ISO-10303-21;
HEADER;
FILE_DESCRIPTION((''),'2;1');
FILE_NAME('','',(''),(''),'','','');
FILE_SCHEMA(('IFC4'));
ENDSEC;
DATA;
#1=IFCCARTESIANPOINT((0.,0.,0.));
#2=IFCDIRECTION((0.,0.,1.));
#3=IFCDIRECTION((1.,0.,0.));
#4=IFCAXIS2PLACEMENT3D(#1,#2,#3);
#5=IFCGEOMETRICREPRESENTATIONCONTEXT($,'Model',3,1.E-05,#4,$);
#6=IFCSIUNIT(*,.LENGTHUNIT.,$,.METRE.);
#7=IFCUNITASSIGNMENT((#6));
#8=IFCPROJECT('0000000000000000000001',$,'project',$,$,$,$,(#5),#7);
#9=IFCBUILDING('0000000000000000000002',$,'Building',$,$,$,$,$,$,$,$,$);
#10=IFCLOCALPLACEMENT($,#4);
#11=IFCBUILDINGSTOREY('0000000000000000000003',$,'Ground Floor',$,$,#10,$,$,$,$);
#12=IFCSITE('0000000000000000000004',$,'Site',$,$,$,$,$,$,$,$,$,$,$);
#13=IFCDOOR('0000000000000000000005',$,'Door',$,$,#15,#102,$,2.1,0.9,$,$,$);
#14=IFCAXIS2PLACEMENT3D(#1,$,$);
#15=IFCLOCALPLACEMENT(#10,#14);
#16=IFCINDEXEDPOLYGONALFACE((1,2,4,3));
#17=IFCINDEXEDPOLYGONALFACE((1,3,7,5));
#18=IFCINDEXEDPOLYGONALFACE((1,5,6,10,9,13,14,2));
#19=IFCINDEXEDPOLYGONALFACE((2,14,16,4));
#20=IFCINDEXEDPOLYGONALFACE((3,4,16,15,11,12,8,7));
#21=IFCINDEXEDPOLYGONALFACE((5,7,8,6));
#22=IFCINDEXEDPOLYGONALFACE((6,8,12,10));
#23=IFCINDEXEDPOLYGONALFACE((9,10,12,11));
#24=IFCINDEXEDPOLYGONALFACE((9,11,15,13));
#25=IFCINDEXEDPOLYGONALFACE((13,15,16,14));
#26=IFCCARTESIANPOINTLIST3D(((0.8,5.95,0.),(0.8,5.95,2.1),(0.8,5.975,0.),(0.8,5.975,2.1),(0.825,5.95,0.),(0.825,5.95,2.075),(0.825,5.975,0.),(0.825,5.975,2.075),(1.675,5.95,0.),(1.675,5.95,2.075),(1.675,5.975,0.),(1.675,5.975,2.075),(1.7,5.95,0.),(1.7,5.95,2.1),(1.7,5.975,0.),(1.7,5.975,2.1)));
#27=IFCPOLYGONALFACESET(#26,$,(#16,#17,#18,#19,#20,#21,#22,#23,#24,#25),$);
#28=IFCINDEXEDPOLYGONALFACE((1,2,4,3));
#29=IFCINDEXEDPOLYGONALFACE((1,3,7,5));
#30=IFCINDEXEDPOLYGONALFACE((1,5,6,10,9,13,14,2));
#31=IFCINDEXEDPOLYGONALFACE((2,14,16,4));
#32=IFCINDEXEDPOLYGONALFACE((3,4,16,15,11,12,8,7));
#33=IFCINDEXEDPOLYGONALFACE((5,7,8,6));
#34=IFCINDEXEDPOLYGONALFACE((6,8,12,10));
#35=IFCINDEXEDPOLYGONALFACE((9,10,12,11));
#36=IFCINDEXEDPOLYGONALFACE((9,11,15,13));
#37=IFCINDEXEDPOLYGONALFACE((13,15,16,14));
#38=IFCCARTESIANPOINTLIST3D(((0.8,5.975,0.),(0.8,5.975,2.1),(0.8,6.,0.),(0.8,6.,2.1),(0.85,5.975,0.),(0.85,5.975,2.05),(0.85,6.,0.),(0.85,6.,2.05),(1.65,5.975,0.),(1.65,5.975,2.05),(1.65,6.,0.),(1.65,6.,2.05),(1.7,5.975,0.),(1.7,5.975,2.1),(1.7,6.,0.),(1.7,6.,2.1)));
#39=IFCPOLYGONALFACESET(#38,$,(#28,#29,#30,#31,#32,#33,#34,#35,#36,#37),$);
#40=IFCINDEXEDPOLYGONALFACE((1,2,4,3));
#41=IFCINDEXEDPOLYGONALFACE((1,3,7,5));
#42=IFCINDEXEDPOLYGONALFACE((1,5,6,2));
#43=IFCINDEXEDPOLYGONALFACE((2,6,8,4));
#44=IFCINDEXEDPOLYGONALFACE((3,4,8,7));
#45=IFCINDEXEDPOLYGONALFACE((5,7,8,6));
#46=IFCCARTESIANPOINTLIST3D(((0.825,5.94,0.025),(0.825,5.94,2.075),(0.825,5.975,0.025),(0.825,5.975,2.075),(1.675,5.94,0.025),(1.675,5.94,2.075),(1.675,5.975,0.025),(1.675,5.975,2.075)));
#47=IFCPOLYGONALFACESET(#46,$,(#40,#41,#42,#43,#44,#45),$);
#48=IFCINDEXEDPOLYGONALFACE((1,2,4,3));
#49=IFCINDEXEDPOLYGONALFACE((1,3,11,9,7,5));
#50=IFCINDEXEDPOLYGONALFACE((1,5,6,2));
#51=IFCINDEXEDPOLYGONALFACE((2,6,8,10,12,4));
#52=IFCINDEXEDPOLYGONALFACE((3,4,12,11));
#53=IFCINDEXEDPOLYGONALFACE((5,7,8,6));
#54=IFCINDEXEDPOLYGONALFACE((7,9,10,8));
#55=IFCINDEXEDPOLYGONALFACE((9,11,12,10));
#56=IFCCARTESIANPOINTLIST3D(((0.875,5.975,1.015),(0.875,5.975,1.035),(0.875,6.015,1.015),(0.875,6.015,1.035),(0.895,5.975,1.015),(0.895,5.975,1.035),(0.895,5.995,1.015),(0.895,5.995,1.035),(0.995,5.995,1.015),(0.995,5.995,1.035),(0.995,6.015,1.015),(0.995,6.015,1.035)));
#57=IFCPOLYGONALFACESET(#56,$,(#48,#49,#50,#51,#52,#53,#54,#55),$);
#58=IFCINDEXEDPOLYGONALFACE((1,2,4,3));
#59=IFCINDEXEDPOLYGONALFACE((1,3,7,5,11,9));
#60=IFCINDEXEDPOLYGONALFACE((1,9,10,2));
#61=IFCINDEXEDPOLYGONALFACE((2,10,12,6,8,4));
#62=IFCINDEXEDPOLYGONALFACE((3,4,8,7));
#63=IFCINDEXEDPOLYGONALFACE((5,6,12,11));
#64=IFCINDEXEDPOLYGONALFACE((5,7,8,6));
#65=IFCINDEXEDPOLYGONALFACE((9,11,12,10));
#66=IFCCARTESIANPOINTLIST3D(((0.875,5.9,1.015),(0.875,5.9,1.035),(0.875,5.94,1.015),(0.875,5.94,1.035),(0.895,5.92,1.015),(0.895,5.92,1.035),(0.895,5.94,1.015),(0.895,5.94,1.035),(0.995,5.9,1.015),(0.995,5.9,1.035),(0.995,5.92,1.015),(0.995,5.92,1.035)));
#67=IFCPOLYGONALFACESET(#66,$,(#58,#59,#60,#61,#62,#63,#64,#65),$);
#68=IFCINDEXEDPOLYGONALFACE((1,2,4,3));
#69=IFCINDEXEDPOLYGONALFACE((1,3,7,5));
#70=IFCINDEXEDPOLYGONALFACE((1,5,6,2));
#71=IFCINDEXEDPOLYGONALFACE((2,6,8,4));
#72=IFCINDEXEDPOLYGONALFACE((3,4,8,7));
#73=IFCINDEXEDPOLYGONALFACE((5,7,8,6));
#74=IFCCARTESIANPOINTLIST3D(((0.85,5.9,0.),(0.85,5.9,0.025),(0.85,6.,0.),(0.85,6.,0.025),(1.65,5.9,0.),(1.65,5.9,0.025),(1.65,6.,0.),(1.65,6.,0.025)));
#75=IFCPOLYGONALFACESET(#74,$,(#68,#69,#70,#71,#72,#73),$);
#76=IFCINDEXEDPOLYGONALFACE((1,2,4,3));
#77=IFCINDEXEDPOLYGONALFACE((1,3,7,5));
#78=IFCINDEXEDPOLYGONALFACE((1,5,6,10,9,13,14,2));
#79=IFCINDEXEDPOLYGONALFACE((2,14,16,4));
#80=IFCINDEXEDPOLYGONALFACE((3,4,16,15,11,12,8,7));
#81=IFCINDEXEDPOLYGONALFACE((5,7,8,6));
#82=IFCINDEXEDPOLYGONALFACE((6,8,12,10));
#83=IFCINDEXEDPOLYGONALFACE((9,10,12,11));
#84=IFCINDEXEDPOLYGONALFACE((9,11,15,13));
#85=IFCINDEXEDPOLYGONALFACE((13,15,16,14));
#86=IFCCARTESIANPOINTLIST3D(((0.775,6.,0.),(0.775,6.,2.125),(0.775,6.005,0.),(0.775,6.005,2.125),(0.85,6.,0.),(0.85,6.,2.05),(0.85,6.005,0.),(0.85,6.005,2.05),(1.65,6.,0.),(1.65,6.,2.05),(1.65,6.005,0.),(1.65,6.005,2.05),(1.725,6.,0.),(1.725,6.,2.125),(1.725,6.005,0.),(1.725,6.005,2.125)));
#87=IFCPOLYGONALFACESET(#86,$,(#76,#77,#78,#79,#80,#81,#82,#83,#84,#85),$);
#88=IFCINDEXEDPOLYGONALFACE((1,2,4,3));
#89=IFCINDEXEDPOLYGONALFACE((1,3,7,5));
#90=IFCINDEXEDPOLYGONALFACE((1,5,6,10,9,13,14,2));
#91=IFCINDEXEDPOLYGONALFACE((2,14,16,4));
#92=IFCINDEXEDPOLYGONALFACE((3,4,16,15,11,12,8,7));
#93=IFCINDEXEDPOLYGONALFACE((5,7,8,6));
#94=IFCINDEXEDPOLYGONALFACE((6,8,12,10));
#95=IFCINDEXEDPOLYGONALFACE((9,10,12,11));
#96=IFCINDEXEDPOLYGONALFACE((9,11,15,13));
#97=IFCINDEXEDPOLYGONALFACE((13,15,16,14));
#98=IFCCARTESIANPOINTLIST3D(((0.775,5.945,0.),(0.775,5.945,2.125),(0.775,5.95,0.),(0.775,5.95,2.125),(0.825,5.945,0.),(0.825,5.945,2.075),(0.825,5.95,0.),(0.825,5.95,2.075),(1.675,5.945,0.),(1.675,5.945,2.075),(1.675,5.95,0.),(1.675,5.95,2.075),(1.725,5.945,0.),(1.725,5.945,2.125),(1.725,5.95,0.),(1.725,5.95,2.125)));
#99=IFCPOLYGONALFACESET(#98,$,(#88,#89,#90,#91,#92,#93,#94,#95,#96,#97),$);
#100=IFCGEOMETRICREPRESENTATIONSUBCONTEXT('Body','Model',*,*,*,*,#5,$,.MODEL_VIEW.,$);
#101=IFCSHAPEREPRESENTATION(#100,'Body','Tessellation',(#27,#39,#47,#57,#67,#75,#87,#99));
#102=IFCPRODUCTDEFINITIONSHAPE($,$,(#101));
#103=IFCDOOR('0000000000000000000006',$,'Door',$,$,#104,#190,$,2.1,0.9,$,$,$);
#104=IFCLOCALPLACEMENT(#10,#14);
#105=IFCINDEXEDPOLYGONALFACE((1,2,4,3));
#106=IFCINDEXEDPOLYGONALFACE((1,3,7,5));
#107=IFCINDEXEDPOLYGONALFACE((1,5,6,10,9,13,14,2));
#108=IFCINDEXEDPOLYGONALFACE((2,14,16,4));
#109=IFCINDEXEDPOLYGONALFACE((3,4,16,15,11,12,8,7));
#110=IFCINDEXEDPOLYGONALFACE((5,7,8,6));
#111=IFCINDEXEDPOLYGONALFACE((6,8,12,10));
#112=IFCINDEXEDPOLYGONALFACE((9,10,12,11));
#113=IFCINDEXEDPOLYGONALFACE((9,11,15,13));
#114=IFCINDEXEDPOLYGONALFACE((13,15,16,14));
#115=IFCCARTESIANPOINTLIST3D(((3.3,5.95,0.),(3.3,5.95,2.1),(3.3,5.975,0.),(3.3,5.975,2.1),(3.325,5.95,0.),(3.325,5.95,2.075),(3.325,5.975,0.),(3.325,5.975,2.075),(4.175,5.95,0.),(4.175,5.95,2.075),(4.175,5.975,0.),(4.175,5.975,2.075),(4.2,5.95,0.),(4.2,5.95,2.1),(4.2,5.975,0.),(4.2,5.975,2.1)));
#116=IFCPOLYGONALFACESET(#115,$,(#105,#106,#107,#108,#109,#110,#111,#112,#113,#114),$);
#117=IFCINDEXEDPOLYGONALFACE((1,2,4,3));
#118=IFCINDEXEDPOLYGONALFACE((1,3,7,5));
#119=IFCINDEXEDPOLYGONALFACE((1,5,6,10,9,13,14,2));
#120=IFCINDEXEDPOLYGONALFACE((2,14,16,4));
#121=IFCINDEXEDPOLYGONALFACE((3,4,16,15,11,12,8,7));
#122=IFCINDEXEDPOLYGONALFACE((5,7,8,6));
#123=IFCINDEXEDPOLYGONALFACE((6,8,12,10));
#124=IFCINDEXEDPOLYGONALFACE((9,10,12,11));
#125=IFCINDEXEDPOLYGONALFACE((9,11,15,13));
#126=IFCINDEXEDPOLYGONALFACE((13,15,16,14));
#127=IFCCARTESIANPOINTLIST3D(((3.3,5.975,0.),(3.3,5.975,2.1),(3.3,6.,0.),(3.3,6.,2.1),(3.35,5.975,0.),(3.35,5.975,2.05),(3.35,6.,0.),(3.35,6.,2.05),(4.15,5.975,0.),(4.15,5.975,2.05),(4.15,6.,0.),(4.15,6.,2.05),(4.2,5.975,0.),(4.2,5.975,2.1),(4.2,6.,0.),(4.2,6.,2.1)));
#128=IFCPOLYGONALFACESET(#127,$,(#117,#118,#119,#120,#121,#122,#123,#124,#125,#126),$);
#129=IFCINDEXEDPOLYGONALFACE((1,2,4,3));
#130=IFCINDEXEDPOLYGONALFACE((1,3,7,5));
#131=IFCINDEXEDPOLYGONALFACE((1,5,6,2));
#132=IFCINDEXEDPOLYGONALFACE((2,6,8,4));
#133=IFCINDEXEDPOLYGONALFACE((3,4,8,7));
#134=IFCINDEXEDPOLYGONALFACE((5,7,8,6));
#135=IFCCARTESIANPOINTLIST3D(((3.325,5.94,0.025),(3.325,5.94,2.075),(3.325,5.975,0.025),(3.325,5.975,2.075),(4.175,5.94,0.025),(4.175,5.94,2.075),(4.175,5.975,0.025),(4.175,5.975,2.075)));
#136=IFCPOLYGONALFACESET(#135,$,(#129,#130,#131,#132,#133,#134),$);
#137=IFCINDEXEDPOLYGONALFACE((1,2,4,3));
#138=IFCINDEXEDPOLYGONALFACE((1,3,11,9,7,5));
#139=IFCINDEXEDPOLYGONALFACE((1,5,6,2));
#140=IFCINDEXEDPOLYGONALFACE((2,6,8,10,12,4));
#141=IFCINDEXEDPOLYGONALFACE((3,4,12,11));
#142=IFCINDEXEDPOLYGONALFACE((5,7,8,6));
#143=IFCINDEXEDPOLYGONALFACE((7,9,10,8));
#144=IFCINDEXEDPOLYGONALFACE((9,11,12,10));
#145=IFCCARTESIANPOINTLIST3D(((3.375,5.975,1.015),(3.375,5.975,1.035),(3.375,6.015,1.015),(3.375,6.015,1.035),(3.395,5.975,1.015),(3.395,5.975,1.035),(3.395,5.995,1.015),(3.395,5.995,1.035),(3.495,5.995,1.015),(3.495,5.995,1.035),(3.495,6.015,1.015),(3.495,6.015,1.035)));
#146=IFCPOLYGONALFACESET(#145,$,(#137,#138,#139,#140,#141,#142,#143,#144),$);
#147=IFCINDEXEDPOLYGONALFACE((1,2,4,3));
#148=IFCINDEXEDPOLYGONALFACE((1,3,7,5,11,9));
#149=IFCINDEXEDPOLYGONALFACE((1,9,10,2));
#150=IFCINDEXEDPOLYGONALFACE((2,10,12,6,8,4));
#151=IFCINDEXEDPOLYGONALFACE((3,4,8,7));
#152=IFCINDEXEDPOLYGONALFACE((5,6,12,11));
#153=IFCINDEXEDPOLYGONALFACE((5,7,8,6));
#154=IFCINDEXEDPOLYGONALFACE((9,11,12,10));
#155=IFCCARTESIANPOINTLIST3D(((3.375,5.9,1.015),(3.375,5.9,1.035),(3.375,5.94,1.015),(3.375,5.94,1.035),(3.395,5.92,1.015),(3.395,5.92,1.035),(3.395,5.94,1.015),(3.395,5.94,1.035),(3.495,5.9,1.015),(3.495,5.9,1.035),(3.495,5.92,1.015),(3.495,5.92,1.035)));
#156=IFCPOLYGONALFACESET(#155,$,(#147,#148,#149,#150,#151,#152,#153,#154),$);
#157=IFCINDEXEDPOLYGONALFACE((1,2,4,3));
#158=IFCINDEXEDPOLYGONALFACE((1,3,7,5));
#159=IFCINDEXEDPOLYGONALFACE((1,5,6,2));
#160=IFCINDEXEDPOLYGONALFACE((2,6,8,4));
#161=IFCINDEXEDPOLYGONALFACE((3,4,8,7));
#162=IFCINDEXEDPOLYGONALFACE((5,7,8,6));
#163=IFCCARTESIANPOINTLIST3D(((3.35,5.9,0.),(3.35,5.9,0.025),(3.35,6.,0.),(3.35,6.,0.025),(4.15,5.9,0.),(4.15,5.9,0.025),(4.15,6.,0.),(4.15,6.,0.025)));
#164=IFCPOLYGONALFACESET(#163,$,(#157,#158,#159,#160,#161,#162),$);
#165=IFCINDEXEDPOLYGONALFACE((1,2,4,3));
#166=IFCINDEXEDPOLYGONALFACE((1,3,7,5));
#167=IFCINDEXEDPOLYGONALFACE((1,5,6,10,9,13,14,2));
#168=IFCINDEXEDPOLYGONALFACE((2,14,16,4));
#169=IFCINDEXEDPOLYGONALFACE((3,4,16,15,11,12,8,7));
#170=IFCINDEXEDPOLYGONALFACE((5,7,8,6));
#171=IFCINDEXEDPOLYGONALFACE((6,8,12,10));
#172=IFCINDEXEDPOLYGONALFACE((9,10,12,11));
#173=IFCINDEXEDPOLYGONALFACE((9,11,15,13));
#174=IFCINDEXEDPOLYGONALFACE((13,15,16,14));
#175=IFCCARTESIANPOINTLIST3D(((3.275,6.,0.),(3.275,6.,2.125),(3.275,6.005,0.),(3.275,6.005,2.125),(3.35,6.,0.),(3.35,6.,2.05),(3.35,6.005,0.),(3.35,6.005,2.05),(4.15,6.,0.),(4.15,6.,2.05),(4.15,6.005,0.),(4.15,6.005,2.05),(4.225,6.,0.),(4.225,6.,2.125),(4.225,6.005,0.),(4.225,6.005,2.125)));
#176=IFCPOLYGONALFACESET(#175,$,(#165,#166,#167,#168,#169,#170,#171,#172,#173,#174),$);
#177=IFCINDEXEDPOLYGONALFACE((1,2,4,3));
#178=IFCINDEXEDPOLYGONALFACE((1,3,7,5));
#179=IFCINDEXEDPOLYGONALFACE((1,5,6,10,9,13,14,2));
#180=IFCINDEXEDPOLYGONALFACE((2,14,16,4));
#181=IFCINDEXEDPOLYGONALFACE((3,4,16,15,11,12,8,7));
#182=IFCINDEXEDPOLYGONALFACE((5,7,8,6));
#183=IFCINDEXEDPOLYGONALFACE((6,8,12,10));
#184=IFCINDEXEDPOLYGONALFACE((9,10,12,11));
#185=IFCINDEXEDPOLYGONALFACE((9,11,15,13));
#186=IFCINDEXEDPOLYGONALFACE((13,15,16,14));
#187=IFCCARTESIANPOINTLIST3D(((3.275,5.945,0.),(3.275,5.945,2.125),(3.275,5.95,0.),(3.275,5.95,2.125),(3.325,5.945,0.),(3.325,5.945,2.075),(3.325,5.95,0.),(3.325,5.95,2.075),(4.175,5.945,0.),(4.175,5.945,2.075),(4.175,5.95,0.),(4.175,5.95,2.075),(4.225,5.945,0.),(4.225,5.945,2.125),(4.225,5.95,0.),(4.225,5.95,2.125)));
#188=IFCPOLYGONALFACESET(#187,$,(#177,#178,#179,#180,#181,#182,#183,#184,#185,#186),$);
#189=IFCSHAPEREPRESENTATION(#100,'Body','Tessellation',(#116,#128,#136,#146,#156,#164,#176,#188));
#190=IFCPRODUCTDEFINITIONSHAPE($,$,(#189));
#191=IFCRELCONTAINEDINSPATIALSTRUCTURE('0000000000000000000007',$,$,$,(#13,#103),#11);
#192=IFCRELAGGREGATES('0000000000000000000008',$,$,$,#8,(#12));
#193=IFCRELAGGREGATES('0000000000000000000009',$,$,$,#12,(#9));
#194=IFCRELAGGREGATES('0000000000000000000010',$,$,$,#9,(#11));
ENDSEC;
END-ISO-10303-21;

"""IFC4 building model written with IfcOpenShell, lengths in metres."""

from ifc_helpers import new_model, si_unit, frame, origin_with_axes, place, context, subcontext, project, spatial, line, indexed_curve, outline, extrude, element, save


model = new_model("IFC4")

# Units and contexts
model_context = context("Model", 3, precision=1e-05, world=origin_with_axes())
body_context = subcontext(model_context, "Body", "Model", "MODEL_VIEW")
ifc_project = project(units=[si_unit("LENGTHUNIT", "METRE")], contexts=[model_context])

# Site, building, storey
site = spatial("IfcSite", under=ifc_project, Name="Site")
building = spatial("IfcBuilding", under=site, Name="Building")
storey_placement = place(None, origin_with_axes())
storey = spatial("IfcBuildingStorey", under=building, at=storey_placement, Name="Ground Floor")

# Doors
door_1_placement = place(storey_placement, frame((1.7, 6.0, 0.0), z_axis=(0.0, 0.0, 1.0), x_axis=(-1.0, 0.0, 0.0)))
element("IfcDoor", 1, at=door_1_placement, inside=storey, Name="Door", OverallHeight=2.1, OverallWidth=0.9, context=body_context, shape_type="SweptSolid", body=[
    extrude(outline(indexed_curve([(0.0, 0.0), (0.0, 2.1), (0.9, 2.1), (0.9, 0.0), (0.875, 0.0), (0.875, 2.075), (0.025, 2.075), (0.025, 0.0)], segments=[line(1, 2, 3, 4, 5, 6, 7, 8, 1)])), frame((0.0, 0.025, 0.0), z_axis=(0.0, -1.0, 0.0), x_axis=(1.0, 0.0, 0.0)), (0.0, 0.0, -1.0), 0.025),
    extrude(outline(indexed_curve([(0.0, 0.0), (0.0, 2.1), (0.9, 2.1), (0.9, 0.0), (0.85, 0.0), (0.85, 2.05), (0.05, 2.05), (0.05, 0.0)], segments=[line(1, 2, 3, 4, 5, 6, 7, 8, 1)])), frame((0.0, 0.0, 0.0), z_axis=(0.0, -1.0, 0.0), x_axis=(1.0, 0.0, 0.0)), (0.0, 0.0, -1.0), 0.025),
    extrude(outline(indexed_curve([(0.0, 0.0), (0.85, 0.0), (0.85, 0.035), (0.0, 0.035)], segments=[line(1, 2, 3, 4, 1)])), frame((0.025, 0.025, 0.025), z_axis=(0.0, 0.0, 1.0), x_axis=(1.0, 0.0, 0.0)), (0.0, 0.0, 1.0), 2.05),
    extrude(outline(indexed_curve([(0.0, 0.0), (0.0, -0.04), (-0.12, -0.04), (-0.12, -0.02), (-0.02, -0.02), (-0.02, 0.0)], segments=[line(1, 2, 3, 4, 5, 6, 1)])), frame((0.825, 0.025, 1.015), z_axis=(0.0, 0.0, 1.0), x_axis=(1.0, 0.0, 0.0)), (0.0, 0.0, 1.0), 0.02),
    extrude(outline(indexed_curve([(0.0, 0.0), (0.0, 0.04), (-0.12, 0.04), (-0.12, 0.02), (-0.02, 0.02), (-0.02, 0.0)], segments=[line(1, 2, 3, 4, 5, 6, 1)])), frame((0.825, 0.06, 1.015), z_axis=(0.0, 0.0, 1.0), x_axis=(1.0, 0.0, 0.0)), (0.0, 0.0, 1.0), 0.02),
    extrude(outline(indexed_curve([(0.0, 0.0), (0.8, 0.0), (0.8, 0.1), (0.0, 0.1)], segments=[line(1, 2, 3, 4, 1)])), frame((0.05, 0.0, 0.0), z_axis=(0.0, 0.0, 1.0), x_axis=(1.0, 0.0, 0.0)), (0.0, 0.0, 1.0), 0.025),
    extrude(outline(indexed_curve([(0.0, 0.0), (0.0, 2.125), (0.95, 2.125), (0.95, 0.0), (0.875, 0.0), (0.875, 2.05), (0.075, 2.05), (0.075, 0.0)], segments=[line(1, 2, 3, 4, 5, 6, 7, 8, 1)])), frame((-0.025, -0.005, 0.0), z_axis=(0.0, -1.0, 0.0), x_axis=(1.0, 0.0, 0.0)), (0.0, 0.0, -1.0), 0.005),
    extrude(outline(indexed_curve([(0.0, 0.0), (0.0, 2.125), (0.95, 2.125), (0.95, 0.0), (0.9, 0.0), (0.9, 2.075), (0.05, 2.075), (0.05, 0.0)], segments=[line(1, 2, 3, 4, 5, 6, 7, 8, 1)])), frame((-0.025, 0.05, 0.0), z_axis=(0.0, -1.0, 0.0), x_axis=(1.0, 0.0, 0.0)), (0.0, 0.0, -1.0), 0.005),
])
door_2_placement = place(storey_placement, frame((4.2, 6.0, 0.0), z_axis=(0.0, 0.0, 1.0), x_axis=(-1.0, 0.0, 0.0)))
element("IfcDoor", 2, at=door_2_placement, inside=storey, Name="Door", OverallHeight=2.1, OverallWidth=0.9, context=body_context, shape_type="SweptSolid", body=[
    extrude(outline(indexed_curve([(0.0, 0.0), (0.0, 2.1), (0.9, 2.1), (0.9, 0.0), (0.875, 0.0), (0.875, 2.075), (0.025, 2.075), (0.025, 0.0)], segments=[line(1, 2, 3, 4, 5, 6, 7, 8, 1)])), frame((0.0, 0.025, 0.0), z_axis=(0.0, -1.0, 0.0), x_axis=(1.0, 0.0, 0.0)), (0.0, 0.0, -1.0), 0.025),
    extrude(outline(indexed_curve([(0.0, 0.0), (0.0, 2.1), (0.9, 2.1), (0.9, 0.0), (0.85, 0.0), (0.85, 2.05), (0.05, 2.05), (0.05, 0.0)], segments=[line(1, 2, 3, 4, 5, 6, 7, 8, 1)])), frame((0.0, 0.0, 0.0), z_axis=(0.0, -1.0, 0.0), x_axis=(1.0, 0.0, 0.0)), (0.0, 0.0, -1.0), 0.025),
    extrude(outline(indexed_curve([(0.0, 0.0), (0.85, 0.0), (0.85, 0.035), (0.0, 0.035)], segments=[line(1, 2, 3, 4, 1)])), frame((0.025, 0.025, 0.025), z_axis=(0.0, 0.0, 1.0), x_axis=(1.0, 0.0, 0.0)), (0.0, 0.0, 1.0), 2.05),
    extrude(outline(indexed_curve([(0.0, 0.0), (0.0, -0.04), (-0.12, -0.04), (-0.12, -0.02), (-0.02, -0.02), (-0.02, 0.0)], segments=[line(1, 2, 3, 4, 5, 6, 1)])), frame((0.825, 0.025, 1.015), z_axis=(0.0, 0.0, 1.0), x_axis=(1.0, 0.0, 0.0)), (0.0, 0.0, 1.0), 0.02),
    extrude(outline(indexed_curve([(0.0, 0.0), (0.0, 0.04), (-0.12, 0.04), (-0.12, 0.02), (-0.02, 0.02), (-0.02, 0.0)], segments=[line(1, 2, 3, 4, 5, 6, 1)])), frame((0.825, 0.06, 1.015), z_axis=(0.0, 0.0, 1.0), x_axis=(1.0, 0.0, 0.0)), (0.0, 0.0, 1.0), 0.02),
    extrude(outline(indexed_curve([(0.0, 0.0), (0.8, 0.0), (0.8, 0.1), (0.0, 0.1)], segments=[line(1, 2, 3, 4, 1)])), frame((0.05, 0.0, 0.0), z_axis=(0.0, 0.0, 1.0), x_axis=(1.0, 0.0, 0.0)), (0.0, 0.0, 1.0), 0.025),
    extrude(outline(indexed_curve([(0.0, 0.0), (0.0, 2.125), (0.95, 2.125), (0.95, 0.0), (0.875, 0.0), (0.875, 2.05), (0.075, 2.05), (0.075, 0.0)], segments=[line(1, 2, 3, 4, 5, 6, 7, 8, 1)])), frame((-0.025, -0.005, 0.0), z_axis=(0.0, -1.0, 0.0), x_axis=(1.0, 0.0, 0.0)), (0.0, 0.0, -1.0), 0.005),
    extrude(outline(indexed_curve([(0.0, 0.0), (0.0, 2.125), (0.95, 2.125), (0.95, 0.0), (0.9, 0.0), (0.9, 2.075), (0.05, 2.075), (0.05, 0.0)], segments=[line(1, 2, 3, 4, 5, 6, 7, 8, 1)])), frame((-0.025, 0.05, 0.0), z_axis=(0.0, -1.0, 0.0), x_axis=(1.0, 0.0, 0.0)), (0.0, 0.0, -1.0), 0.005),
])

save(model, "model.ifc")
